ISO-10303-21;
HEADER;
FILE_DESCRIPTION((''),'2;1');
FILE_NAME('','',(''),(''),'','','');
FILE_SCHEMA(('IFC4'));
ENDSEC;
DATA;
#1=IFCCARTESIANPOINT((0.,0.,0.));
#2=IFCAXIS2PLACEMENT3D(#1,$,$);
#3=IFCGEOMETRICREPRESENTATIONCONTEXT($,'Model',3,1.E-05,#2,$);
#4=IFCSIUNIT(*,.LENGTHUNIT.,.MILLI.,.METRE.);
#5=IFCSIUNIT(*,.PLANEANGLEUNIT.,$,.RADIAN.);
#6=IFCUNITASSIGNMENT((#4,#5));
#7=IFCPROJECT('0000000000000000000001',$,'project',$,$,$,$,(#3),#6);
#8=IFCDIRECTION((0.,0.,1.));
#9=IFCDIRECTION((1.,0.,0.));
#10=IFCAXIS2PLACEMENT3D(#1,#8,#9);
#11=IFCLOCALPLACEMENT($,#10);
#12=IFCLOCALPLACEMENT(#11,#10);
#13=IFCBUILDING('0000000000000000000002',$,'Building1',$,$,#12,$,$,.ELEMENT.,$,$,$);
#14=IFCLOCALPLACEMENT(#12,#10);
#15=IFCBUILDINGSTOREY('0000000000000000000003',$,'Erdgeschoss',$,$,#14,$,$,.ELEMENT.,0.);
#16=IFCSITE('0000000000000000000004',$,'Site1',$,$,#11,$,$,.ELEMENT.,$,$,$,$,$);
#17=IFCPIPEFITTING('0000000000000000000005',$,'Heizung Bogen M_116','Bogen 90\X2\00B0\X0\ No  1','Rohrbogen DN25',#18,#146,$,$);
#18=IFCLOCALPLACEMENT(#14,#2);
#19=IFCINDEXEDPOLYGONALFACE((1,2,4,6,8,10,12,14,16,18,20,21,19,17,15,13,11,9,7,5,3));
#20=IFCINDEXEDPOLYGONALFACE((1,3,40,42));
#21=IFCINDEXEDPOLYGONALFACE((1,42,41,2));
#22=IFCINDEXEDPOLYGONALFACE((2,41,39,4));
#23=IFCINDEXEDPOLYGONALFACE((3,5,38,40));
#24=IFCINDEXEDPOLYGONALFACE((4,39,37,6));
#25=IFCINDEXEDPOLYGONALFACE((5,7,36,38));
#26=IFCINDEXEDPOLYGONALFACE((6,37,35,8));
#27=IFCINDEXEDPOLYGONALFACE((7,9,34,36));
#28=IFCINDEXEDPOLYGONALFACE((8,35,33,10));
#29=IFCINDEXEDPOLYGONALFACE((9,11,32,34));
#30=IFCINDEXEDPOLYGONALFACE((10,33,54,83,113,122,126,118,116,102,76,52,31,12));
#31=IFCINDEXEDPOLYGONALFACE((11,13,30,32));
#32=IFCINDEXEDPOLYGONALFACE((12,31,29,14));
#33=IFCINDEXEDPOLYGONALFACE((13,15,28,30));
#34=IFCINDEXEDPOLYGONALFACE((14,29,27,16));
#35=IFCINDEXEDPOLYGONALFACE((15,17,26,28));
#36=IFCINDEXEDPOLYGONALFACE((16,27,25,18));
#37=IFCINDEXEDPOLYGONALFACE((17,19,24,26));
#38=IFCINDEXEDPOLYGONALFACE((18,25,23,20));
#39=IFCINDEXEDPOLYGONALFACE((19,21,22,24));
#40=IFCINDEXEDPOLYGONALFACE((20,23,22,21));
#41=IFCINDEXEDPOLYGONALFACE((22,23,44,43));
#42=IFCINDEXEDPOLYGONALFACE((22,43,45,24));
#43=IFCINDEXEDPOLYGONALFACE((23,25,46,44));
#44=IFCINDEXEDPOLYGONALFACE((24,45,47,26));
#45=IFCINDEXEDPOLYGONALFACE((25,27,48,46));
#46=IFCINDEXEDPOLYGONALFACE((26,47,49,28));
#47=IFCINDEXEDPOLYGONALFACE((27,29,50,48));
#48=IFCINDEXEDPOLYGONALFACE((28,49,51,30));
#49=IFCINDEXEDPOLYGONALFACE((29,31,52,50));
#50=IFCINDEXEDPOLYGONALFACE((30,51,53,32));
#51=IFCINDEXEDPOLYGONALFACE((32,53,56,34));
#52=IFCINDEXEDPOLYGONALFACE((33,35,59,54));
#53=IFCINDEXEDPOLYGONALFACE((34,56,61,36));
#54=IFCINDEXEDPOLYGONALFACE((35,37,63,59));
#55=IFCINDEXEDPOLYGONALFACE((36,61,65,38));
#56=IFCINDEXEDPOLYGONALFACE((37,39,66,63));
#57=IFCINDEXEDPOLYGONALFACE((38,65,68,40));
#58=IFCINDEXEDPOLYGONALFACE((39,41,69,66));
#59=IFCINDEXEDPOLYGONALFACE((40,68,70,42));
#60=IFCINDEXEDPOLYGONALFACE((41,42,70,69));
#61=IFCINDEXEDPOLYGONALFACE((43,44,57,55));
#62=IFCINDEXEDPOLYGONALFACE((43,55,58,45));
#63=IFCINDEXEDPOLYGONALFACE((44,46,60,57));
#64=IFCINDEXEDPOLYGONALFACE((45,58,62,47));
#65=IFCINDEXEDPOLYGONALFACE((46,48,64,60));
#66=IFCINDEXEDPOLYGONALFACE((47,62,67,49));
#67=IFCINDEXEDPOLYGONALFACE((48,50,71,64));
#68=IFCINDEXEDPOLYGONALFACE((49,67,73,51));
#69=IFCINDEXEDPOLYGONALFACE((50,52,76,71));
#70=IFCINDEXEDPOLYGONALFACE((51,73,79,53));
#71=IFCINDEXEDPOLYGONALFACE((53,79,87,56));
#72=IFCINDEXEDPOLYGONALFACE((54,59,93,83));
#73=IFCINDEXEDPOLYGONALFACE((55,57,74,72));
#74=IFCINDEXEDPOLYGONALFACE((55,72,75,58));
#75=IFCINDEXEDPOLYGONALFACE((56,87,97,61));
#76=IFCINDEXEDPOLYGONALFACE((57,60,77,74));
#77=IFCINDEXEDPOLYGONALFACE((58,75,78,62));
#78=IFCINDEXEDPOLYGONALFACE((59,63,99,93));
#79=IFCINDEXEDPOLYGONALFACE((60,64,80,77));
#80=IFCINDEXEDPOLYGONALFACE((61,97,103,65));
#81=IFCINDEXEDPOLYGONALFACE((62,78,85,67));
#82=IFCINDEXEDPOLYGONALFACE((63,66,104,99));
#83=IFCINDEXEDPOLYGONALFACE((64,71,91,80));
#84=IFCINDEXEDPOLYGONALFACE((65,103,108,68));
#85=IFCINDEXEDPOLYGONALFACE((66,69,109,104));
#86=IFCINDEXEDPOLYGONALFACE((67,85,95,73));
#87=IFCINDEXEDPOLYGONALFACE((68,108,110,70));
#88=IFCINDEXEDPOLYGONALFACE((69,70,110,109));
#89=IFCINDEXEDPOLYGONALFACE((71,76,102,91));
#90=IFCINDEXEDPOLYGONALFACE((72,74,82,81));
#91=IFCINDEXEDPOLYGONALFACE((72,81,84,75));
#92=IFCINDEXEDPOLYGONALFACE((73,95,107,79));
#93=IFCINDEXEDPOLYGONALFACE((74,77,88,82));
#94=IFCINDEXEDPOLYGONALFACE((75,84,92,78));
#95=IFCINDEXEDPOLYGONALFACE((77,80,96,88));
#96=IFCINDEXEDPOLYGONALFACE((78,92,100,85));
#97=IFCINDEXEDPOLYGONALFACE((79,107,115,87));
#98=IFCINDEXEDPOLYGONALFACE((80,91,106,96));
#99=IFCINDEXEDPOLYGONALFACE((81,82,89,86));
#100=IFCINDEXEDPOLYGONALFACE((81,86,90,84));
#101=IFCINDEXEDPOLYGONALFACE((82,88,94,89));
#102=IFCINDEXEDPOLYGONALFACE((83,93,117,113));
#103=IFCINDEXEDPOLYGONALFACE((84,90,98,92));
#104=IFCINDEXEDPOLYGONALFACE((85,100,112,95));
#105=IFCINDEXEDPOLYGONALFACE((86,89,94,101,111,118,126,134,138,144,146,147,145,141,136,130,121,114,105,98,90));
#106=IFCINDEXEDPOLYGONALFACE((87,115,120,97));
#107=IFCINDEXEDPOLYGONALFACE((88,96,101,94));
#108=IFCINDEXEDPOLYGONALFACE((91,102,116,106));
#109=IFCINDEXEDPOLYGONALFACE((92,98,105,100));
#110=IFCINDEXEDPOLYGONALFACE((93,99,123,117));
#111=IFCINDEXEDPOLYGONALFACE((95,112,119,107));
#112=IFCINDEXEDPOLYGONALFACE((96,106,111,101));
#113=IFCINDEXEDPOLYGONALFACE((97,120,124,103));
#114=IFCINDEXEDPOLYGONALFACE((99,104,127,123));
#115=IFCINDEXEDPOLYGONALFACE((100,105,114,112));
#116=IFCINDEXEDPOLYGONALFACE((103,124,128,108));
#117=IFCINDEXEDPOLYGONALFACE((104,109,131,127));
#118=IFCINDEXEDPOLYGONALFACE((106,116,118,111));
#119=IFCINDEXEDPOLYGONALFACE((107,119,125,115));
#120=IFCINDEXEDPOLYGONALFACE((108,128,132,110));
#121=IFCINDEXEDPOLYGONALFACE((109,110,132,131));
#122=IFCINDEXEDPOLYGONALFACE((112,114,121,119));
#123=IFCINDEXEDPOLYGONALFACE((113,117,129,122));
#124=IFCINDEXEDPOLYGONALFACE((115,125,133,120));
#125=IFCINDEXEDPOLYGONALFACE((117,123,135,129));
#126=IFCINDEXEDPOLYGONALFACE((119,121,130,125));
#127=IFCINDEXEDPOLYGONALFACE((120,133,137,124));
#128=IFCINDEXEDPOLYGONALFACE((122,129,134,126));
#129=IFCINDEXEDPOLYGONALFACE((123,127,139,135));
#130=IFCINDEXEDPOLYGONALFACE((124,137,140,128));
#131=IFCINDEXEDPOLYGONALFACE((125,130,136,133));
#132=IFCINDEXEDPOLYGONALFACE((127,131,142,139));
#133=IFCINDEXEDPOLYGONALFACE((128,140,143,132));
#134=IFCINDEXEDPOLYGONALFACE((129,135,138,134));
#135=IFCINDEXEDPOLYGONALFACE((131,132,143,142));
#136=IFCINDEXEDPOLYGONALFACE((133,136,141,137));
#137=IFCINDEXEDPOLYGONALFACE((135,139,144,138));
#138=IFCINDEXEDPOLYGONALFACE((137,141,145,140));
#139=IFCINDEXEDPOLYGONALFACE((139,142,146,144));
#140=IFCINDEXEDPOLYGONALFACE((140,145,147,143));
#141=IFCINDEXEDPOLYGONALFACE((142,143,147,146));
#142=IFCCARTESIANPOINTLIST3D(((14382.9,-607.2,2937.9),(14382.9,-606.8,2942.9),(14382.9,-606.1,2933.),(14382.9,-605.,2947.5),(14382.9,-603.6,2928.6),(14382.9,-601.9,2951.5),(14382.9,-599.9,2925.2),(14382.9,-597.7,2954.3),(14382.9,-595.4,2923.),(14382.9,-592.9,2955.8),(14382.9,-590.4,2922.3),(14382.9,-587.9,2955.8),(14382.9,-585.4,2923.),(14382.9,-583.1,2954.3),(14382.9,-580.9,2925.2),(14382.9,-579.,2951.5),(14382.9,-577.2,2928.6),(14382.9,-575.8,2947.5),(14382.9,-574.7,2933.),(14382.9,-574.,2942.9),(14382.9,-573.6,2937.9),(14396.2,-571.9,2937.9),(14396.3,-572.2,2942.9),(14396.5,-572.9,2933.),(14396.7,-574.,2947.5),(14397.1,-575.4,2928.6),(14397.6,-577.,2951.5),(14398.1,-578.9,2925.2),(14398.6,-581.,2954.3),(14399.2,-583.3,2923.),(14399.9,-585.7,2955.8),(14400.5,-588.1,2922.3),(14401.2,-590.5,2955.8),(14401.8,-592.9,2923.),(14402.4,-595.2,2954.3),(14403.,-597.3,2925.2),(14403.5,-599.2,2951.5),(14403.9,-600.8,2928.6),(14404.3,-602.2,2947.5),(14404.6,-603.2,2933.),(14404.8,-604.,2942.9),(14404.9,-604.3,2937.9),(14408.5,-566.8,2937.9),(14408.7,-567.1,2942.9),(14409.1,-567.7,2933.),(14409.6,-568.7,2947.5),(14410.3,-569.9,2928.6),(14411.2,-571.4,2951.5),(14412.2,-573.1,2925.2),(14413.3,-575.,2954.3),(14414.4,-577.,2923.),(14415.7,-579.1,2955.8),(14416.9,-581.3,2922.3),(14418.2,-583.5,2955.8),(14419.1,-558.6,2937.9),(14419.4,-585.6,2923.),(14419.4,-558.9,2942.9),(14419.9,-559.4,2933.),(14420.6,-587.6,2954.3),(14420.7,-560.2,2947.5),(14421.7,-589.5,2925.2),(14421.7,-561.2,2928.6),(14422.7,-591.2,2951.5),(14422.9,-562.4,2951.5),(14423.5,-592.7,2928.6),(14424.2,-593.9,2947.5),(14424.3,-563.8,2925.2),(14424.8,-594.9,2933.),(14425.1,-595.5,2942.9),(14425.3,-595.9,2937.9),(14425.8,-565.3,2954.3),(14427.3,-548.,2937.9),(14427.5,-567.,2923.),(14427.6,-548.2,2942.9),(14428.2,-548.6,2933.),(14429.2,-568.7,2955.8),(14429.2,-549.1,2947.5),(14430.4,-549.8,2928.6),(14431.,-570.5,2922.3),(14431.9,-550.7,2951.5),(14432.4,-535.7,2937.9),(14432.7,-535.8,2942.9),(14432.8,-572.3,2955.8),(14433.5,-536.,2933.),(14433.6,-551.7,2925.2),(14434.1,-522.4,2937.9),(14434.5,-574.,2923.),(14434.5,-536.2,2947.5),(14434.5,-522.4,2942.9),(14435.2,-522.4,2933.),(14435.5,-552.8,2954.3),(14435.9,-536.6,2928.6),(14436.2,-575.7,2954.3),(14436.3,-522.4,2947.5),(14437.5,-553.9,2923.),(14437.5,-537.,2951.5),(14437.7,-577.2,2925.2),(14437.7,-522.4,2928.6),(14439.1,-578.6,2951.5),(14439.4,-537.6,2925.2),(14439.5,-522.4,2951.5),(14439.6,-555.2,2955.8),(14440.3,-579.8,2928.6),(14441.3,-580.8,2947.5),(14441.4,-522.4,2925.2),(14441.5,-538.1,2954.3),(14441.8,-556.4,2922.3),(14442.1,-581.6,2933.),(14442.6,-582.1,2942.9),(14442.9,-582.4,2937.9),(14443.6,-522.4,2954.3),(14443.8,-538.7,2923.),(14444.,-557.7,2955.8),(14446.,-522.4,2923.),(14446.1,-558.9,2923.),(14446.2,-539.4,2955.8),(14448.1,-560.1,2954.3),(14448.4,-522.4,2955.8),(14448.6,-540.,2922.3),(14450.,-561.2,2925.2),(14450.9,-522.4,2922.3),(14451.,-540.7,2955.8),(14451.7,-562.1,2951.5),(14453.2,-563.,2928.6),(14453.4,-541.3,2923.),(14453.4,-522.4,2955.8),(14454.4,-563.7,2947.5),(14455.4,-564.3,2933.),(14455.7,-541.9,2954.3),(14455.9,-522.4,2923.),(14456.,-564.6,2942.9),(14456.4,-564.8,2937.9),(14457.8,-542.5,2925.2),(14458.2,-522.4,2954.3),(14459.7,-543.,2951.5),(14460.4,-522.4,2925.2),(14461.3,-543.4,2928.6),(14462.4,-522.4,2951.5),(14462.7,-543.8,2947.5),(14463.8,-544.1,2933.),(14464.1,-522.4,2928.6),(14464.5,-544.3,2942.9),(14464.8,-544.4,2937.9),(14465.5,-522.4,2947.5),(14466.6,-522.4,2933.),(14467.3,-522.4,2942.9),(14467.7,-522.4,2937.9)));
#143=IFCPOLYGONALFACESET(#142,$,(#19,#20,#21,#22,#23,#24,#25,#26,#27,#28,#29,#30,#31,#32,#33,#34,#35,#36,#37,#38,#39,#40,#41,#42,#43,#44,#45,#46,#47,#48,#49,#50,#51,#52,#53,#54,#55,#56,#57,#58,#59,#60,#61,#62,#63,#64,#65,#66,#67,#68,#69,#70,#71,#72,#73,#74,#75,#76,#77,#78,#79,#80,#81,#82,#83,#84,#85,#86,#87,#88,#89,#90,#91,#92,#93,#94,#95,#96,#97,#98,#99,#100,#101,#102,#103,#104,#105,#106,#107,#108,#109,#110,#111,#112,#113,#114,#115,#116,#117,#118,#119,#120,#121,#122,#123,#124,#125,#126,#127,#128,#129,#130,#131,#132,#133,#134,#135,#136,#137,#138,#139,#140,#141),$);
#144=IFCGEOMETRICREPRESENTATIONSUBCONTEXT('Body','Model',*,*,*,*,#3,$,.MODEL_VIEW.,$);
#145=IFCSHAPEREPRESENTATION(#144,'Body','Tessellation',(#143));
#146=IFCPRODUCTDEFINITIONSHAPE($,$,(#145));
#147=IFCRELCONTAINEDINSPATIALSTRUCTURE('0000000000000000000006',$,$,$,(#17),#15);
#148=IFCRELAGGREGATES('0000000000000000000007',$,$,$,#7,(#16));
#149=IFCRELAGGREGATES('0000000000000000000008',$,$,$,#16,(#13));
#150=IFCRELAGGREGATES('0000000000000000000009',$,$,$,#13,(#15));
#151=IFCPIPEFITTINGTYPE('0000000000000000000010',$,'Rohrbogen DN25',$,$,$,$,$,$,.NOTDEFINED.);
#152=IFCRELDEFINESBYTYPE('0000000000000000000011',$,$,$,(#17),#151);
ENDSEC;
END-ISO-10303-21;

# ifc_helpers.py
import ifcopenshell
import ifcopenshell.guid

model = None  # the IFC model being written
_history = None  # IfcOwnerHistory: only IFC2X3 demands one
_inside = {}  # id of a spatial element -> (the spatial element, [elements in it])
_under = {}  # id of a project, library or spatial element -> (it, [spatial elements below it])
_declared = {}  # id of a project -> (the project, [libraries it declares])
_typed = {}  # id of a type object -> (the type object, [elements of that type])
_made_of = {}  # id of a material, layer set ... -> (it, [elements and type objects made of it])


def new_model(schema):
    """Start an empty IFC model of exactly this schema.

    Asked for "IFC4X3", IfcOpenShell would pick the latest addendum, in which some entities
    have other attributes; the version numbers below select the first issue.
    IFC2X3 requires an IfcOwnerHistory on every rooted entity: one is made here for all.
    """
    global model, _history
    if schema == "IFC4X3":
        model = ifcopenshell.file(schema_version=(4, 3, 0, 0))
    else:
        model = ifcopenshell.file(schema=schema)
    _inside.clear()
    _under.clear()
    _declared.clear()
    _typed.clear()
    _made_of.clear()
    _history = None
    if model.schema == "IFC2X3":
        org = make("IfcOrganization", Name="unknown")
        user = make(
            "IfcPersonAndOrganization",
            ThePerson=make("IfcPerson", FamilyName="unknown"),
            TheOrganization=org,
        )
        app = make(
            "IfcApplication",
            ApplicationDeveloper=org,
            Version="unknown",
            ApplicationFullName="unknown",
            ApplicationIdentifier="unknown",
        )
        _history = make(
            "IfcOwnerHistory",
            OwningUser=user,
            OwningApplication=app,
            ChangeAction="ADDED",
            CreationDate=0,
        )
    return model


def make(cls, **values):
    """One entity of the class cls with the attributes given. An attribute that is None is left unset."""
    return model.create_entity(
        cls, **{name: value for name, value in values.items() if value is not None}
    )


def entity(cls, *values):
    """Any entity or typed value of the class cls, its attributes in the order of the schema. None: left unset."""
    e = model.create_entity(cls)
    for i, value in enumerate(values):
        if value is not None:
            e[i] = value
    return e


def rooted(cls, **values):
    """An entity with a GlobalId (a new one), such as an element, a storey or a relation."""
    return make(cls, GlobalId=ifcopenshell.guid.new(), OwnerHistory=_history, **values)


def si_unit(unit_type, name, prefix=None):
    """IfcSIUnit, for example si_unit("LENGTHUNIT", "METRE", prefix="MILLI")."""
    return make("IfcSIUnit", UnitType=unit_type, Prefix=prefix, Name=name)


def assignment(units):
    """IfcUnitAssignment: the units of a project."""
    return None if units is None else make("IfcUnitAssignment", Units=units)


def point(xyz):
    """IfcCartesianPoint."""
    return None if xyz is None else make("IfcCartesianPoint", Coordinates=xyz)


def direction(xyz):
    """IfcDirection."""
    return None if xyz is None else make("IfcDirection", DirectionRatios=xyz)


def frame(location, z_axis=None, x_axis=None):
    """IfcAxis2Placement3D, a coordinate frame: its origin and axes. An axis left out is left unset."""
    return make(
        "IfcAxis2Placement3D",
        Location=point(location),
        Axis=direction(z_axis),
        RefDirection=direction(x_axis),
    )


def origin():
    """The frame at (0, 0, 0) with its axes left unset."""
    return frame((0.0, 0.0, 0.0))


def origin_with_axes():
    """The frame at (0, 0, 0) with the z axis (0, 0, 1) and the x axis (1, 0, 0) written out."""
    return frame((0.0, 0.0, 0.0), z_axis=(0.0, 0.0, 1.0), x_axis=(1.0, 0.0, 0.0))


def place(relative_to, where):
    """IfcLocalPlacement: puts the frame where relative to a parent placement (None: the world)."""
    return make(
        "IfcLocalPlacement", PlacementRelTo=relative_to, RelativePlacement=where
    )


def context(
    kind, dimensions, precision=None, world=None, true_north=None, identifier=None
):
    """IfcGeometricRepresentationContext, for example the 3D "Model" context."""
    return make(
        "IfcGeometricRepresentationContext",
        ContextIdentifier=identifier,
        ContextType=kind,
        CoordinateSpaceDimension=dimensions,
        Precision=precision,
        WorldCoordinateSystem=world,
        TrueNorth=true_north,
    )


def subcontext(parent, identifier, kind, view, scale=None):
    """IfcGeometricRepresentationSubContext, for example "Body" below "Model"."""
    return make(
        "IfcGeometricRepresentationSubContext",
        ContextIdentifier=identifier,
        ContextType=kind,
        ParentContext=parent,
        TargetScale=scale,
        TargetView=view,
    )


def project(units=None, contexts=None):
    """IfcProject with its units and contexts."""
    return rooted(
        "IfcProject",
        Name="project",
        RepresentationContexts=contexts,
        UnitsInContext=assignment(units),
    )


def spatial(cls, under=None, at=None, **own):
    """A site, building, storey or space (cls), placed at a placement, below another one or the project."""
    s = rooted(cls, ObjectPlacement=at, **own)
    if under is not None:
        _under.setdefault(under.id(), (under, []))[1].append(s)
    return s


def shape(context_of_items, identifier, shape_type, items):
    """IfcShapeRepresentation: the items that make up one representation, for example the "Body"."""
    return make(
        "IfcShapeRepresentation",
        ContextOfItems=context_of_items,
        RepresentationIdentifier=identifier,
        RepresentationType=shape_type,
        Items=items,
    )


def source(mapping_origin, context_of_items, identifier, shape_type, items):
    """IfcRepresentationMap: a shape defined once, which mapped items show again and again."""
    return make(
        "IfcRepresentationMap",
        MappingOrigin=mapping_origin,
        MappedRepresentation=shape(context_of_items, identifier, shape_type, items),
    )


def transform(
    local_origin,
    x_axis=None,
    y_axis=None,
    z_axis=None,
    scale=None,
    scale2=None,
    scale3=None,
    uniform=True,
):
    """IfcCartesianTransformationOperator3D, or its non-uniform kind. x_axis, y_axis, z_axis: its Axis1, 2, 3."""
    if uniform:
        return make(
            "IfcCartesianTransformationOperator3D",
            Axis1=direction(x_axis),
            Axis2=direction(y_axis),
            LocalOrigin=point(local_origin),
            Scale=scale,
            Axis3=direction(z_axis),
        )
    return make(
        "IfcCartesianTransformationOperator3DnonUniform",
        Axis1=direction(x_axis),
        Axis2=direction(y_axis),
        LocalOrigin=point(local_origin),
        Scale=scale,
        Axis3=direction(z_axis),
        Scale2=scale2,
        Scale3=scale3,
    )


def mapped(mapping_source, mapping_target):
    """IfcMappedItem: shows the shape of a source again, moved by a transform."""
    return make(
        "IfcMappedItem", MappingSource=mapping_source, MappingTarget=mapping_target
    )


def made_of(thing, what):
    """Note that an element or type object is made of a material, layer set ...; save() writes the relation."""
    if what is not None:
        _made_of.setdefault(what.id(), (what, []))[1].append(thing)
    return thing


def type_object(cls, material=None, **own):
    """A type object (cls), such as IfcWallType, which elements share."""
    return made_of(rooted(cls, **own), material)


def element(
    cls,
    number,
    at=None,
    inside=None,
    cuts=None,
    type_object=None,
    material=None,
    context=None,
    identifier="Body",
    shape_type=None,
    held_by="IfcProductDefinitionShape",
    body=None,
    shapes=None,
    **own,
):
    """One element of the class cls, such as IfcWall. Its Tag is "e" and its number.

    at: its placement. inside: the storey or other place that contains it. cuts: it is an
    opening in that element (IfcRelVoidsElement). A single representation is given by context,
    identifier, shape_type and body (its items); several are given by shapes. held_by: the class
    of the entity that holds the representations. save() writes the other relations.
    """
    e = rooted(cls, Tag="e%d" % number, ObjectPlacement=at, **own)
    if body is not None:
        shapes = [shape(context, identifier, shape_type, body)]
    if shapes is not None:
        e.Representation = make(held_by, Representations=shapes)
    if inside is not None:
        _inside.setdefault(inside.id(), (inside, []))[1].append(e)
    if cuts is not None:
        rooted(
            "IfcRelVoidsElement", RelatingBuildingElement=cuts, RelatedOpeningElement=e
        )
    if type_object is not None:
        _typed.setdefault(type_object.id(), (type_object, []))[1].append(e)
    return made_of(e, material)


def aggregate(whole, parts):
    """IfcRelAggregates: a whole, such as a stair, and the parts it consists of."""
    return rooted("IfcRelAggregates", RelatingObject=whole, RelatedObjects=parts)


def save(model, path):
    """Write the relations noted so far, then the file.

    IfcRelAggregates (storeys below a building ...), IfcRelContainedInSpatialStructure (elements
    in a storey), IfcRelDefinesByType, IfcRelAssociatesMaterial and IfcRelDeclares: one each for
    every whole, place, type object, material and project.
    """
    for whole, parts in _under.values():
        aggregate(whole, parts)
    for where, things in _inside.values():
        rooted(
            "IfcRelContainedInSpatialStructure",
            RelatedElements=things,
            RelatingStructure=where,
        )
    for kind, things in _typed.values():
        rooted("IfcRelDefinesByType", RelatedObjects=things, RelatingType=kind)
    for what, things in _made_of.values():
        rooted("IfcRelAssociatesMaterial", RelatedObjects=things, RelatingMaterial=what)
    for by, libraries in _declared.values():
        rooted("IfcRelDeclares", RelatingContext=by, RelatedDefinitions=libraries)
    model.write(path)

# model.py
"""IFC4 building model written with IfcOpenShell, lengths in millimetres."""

from ifc_helpers import new_model, entity, si_unit, frame, origin, origin_with_axes, place, context, subcontext, project, spatial, source, transform, mapped, type_object, element, save


model = new_model("IFC4")

# Units and contexts
model_context = context("Model", 3, precision=1e-05, world=origin())
body_context = subcontext(model_context, "Body", "Model", "MODEL_VIEW")
ifc_project = project(units=[si_unit("LENGTHUNIT", "METRE", prefix="MILLI"), si_unit("PLANEANGLEUNIT", "RADIAN")], contexts=[model_context])

# Site, building, storey
site_placement = place(None, origin_with_axes())
site = spatial("IfcSite", under=ifc_project, at=site_placement, Name="Site1", CompositionType="ELEMENT")
building_placement = place(site_placement, origin_with_axes())
building = spatial("IfcBuilding", under=site, at=building_placement, Name="Building1", CompositionType="ELEMENT")
storey_placement = place(building_placement, origin_with_axes())
storey = spatial("IfcBuildingStorey", under=building, at=storey_placement, Name="Erdgeschoss", CompositionType="ELEMENT", Elevation=0.0)

# Pipe fitting
pipe_fitting_type = type_object("IfcPipeFittingType", Name="Rohrbogen DN25", PredefinedType="NOTDEFINED")
shared_shape_1 = source(origin_with_axes(), body_context, "Body", "SolidModel", [
    entity("IfcRevolvedAreaSolid", entity("IfcCircleProfileDef", "AREA", None, entity("IfcAxis2Placement2D", entity("IfcCartesianPoint", [0.0, 0.0]), entity("IfcDirection", [1.0, 0.0])), 16.9), entity("IfcAxis2Placement3D", entity("IfcCartesianPoint", [-42.4, 25.6, 0.0]), entity("IfcDirection", [1.0, 0.0, 0.0]), entity("IfcDirection", [0.0, 0.0, 1.0])), entity("IfcAxis1Placement", entity("IfcCartesianPoint", [0.0, 68.0, 0.0]), entity("IfcDirection", [-1.0, 0.0, 0.0])), 1.570796),
])
pipe_fitting_1_placement = place(storey_placement, frame((14425.3, -564.8, 2939.1), z_axis=(0.0, 0.0, 1.0), x_axis=(1.0, 0.0, 0.0)))
element("IfcPipeFitting", 1, at=pipe_fitting_1_placement, inside=storey, type_object=pipe_fitting_type, Name="Heizung Bogen M_116", Description="Bogen 90° No  1", ObjectType="Rohrbogen DN25", context=body_context, shape_type="MappedRepresentation", body=[
    mapped(shared_shape_1, transform((0.0, 0.0, 0.0), x_axis=(1.0, 0.0, 0.0), y_axis=(0.0, -1.0, 0.0), z_axis=(0.0, 0.0, -1.0), scale=1.0)),
])

save(model, "model.ifc")
